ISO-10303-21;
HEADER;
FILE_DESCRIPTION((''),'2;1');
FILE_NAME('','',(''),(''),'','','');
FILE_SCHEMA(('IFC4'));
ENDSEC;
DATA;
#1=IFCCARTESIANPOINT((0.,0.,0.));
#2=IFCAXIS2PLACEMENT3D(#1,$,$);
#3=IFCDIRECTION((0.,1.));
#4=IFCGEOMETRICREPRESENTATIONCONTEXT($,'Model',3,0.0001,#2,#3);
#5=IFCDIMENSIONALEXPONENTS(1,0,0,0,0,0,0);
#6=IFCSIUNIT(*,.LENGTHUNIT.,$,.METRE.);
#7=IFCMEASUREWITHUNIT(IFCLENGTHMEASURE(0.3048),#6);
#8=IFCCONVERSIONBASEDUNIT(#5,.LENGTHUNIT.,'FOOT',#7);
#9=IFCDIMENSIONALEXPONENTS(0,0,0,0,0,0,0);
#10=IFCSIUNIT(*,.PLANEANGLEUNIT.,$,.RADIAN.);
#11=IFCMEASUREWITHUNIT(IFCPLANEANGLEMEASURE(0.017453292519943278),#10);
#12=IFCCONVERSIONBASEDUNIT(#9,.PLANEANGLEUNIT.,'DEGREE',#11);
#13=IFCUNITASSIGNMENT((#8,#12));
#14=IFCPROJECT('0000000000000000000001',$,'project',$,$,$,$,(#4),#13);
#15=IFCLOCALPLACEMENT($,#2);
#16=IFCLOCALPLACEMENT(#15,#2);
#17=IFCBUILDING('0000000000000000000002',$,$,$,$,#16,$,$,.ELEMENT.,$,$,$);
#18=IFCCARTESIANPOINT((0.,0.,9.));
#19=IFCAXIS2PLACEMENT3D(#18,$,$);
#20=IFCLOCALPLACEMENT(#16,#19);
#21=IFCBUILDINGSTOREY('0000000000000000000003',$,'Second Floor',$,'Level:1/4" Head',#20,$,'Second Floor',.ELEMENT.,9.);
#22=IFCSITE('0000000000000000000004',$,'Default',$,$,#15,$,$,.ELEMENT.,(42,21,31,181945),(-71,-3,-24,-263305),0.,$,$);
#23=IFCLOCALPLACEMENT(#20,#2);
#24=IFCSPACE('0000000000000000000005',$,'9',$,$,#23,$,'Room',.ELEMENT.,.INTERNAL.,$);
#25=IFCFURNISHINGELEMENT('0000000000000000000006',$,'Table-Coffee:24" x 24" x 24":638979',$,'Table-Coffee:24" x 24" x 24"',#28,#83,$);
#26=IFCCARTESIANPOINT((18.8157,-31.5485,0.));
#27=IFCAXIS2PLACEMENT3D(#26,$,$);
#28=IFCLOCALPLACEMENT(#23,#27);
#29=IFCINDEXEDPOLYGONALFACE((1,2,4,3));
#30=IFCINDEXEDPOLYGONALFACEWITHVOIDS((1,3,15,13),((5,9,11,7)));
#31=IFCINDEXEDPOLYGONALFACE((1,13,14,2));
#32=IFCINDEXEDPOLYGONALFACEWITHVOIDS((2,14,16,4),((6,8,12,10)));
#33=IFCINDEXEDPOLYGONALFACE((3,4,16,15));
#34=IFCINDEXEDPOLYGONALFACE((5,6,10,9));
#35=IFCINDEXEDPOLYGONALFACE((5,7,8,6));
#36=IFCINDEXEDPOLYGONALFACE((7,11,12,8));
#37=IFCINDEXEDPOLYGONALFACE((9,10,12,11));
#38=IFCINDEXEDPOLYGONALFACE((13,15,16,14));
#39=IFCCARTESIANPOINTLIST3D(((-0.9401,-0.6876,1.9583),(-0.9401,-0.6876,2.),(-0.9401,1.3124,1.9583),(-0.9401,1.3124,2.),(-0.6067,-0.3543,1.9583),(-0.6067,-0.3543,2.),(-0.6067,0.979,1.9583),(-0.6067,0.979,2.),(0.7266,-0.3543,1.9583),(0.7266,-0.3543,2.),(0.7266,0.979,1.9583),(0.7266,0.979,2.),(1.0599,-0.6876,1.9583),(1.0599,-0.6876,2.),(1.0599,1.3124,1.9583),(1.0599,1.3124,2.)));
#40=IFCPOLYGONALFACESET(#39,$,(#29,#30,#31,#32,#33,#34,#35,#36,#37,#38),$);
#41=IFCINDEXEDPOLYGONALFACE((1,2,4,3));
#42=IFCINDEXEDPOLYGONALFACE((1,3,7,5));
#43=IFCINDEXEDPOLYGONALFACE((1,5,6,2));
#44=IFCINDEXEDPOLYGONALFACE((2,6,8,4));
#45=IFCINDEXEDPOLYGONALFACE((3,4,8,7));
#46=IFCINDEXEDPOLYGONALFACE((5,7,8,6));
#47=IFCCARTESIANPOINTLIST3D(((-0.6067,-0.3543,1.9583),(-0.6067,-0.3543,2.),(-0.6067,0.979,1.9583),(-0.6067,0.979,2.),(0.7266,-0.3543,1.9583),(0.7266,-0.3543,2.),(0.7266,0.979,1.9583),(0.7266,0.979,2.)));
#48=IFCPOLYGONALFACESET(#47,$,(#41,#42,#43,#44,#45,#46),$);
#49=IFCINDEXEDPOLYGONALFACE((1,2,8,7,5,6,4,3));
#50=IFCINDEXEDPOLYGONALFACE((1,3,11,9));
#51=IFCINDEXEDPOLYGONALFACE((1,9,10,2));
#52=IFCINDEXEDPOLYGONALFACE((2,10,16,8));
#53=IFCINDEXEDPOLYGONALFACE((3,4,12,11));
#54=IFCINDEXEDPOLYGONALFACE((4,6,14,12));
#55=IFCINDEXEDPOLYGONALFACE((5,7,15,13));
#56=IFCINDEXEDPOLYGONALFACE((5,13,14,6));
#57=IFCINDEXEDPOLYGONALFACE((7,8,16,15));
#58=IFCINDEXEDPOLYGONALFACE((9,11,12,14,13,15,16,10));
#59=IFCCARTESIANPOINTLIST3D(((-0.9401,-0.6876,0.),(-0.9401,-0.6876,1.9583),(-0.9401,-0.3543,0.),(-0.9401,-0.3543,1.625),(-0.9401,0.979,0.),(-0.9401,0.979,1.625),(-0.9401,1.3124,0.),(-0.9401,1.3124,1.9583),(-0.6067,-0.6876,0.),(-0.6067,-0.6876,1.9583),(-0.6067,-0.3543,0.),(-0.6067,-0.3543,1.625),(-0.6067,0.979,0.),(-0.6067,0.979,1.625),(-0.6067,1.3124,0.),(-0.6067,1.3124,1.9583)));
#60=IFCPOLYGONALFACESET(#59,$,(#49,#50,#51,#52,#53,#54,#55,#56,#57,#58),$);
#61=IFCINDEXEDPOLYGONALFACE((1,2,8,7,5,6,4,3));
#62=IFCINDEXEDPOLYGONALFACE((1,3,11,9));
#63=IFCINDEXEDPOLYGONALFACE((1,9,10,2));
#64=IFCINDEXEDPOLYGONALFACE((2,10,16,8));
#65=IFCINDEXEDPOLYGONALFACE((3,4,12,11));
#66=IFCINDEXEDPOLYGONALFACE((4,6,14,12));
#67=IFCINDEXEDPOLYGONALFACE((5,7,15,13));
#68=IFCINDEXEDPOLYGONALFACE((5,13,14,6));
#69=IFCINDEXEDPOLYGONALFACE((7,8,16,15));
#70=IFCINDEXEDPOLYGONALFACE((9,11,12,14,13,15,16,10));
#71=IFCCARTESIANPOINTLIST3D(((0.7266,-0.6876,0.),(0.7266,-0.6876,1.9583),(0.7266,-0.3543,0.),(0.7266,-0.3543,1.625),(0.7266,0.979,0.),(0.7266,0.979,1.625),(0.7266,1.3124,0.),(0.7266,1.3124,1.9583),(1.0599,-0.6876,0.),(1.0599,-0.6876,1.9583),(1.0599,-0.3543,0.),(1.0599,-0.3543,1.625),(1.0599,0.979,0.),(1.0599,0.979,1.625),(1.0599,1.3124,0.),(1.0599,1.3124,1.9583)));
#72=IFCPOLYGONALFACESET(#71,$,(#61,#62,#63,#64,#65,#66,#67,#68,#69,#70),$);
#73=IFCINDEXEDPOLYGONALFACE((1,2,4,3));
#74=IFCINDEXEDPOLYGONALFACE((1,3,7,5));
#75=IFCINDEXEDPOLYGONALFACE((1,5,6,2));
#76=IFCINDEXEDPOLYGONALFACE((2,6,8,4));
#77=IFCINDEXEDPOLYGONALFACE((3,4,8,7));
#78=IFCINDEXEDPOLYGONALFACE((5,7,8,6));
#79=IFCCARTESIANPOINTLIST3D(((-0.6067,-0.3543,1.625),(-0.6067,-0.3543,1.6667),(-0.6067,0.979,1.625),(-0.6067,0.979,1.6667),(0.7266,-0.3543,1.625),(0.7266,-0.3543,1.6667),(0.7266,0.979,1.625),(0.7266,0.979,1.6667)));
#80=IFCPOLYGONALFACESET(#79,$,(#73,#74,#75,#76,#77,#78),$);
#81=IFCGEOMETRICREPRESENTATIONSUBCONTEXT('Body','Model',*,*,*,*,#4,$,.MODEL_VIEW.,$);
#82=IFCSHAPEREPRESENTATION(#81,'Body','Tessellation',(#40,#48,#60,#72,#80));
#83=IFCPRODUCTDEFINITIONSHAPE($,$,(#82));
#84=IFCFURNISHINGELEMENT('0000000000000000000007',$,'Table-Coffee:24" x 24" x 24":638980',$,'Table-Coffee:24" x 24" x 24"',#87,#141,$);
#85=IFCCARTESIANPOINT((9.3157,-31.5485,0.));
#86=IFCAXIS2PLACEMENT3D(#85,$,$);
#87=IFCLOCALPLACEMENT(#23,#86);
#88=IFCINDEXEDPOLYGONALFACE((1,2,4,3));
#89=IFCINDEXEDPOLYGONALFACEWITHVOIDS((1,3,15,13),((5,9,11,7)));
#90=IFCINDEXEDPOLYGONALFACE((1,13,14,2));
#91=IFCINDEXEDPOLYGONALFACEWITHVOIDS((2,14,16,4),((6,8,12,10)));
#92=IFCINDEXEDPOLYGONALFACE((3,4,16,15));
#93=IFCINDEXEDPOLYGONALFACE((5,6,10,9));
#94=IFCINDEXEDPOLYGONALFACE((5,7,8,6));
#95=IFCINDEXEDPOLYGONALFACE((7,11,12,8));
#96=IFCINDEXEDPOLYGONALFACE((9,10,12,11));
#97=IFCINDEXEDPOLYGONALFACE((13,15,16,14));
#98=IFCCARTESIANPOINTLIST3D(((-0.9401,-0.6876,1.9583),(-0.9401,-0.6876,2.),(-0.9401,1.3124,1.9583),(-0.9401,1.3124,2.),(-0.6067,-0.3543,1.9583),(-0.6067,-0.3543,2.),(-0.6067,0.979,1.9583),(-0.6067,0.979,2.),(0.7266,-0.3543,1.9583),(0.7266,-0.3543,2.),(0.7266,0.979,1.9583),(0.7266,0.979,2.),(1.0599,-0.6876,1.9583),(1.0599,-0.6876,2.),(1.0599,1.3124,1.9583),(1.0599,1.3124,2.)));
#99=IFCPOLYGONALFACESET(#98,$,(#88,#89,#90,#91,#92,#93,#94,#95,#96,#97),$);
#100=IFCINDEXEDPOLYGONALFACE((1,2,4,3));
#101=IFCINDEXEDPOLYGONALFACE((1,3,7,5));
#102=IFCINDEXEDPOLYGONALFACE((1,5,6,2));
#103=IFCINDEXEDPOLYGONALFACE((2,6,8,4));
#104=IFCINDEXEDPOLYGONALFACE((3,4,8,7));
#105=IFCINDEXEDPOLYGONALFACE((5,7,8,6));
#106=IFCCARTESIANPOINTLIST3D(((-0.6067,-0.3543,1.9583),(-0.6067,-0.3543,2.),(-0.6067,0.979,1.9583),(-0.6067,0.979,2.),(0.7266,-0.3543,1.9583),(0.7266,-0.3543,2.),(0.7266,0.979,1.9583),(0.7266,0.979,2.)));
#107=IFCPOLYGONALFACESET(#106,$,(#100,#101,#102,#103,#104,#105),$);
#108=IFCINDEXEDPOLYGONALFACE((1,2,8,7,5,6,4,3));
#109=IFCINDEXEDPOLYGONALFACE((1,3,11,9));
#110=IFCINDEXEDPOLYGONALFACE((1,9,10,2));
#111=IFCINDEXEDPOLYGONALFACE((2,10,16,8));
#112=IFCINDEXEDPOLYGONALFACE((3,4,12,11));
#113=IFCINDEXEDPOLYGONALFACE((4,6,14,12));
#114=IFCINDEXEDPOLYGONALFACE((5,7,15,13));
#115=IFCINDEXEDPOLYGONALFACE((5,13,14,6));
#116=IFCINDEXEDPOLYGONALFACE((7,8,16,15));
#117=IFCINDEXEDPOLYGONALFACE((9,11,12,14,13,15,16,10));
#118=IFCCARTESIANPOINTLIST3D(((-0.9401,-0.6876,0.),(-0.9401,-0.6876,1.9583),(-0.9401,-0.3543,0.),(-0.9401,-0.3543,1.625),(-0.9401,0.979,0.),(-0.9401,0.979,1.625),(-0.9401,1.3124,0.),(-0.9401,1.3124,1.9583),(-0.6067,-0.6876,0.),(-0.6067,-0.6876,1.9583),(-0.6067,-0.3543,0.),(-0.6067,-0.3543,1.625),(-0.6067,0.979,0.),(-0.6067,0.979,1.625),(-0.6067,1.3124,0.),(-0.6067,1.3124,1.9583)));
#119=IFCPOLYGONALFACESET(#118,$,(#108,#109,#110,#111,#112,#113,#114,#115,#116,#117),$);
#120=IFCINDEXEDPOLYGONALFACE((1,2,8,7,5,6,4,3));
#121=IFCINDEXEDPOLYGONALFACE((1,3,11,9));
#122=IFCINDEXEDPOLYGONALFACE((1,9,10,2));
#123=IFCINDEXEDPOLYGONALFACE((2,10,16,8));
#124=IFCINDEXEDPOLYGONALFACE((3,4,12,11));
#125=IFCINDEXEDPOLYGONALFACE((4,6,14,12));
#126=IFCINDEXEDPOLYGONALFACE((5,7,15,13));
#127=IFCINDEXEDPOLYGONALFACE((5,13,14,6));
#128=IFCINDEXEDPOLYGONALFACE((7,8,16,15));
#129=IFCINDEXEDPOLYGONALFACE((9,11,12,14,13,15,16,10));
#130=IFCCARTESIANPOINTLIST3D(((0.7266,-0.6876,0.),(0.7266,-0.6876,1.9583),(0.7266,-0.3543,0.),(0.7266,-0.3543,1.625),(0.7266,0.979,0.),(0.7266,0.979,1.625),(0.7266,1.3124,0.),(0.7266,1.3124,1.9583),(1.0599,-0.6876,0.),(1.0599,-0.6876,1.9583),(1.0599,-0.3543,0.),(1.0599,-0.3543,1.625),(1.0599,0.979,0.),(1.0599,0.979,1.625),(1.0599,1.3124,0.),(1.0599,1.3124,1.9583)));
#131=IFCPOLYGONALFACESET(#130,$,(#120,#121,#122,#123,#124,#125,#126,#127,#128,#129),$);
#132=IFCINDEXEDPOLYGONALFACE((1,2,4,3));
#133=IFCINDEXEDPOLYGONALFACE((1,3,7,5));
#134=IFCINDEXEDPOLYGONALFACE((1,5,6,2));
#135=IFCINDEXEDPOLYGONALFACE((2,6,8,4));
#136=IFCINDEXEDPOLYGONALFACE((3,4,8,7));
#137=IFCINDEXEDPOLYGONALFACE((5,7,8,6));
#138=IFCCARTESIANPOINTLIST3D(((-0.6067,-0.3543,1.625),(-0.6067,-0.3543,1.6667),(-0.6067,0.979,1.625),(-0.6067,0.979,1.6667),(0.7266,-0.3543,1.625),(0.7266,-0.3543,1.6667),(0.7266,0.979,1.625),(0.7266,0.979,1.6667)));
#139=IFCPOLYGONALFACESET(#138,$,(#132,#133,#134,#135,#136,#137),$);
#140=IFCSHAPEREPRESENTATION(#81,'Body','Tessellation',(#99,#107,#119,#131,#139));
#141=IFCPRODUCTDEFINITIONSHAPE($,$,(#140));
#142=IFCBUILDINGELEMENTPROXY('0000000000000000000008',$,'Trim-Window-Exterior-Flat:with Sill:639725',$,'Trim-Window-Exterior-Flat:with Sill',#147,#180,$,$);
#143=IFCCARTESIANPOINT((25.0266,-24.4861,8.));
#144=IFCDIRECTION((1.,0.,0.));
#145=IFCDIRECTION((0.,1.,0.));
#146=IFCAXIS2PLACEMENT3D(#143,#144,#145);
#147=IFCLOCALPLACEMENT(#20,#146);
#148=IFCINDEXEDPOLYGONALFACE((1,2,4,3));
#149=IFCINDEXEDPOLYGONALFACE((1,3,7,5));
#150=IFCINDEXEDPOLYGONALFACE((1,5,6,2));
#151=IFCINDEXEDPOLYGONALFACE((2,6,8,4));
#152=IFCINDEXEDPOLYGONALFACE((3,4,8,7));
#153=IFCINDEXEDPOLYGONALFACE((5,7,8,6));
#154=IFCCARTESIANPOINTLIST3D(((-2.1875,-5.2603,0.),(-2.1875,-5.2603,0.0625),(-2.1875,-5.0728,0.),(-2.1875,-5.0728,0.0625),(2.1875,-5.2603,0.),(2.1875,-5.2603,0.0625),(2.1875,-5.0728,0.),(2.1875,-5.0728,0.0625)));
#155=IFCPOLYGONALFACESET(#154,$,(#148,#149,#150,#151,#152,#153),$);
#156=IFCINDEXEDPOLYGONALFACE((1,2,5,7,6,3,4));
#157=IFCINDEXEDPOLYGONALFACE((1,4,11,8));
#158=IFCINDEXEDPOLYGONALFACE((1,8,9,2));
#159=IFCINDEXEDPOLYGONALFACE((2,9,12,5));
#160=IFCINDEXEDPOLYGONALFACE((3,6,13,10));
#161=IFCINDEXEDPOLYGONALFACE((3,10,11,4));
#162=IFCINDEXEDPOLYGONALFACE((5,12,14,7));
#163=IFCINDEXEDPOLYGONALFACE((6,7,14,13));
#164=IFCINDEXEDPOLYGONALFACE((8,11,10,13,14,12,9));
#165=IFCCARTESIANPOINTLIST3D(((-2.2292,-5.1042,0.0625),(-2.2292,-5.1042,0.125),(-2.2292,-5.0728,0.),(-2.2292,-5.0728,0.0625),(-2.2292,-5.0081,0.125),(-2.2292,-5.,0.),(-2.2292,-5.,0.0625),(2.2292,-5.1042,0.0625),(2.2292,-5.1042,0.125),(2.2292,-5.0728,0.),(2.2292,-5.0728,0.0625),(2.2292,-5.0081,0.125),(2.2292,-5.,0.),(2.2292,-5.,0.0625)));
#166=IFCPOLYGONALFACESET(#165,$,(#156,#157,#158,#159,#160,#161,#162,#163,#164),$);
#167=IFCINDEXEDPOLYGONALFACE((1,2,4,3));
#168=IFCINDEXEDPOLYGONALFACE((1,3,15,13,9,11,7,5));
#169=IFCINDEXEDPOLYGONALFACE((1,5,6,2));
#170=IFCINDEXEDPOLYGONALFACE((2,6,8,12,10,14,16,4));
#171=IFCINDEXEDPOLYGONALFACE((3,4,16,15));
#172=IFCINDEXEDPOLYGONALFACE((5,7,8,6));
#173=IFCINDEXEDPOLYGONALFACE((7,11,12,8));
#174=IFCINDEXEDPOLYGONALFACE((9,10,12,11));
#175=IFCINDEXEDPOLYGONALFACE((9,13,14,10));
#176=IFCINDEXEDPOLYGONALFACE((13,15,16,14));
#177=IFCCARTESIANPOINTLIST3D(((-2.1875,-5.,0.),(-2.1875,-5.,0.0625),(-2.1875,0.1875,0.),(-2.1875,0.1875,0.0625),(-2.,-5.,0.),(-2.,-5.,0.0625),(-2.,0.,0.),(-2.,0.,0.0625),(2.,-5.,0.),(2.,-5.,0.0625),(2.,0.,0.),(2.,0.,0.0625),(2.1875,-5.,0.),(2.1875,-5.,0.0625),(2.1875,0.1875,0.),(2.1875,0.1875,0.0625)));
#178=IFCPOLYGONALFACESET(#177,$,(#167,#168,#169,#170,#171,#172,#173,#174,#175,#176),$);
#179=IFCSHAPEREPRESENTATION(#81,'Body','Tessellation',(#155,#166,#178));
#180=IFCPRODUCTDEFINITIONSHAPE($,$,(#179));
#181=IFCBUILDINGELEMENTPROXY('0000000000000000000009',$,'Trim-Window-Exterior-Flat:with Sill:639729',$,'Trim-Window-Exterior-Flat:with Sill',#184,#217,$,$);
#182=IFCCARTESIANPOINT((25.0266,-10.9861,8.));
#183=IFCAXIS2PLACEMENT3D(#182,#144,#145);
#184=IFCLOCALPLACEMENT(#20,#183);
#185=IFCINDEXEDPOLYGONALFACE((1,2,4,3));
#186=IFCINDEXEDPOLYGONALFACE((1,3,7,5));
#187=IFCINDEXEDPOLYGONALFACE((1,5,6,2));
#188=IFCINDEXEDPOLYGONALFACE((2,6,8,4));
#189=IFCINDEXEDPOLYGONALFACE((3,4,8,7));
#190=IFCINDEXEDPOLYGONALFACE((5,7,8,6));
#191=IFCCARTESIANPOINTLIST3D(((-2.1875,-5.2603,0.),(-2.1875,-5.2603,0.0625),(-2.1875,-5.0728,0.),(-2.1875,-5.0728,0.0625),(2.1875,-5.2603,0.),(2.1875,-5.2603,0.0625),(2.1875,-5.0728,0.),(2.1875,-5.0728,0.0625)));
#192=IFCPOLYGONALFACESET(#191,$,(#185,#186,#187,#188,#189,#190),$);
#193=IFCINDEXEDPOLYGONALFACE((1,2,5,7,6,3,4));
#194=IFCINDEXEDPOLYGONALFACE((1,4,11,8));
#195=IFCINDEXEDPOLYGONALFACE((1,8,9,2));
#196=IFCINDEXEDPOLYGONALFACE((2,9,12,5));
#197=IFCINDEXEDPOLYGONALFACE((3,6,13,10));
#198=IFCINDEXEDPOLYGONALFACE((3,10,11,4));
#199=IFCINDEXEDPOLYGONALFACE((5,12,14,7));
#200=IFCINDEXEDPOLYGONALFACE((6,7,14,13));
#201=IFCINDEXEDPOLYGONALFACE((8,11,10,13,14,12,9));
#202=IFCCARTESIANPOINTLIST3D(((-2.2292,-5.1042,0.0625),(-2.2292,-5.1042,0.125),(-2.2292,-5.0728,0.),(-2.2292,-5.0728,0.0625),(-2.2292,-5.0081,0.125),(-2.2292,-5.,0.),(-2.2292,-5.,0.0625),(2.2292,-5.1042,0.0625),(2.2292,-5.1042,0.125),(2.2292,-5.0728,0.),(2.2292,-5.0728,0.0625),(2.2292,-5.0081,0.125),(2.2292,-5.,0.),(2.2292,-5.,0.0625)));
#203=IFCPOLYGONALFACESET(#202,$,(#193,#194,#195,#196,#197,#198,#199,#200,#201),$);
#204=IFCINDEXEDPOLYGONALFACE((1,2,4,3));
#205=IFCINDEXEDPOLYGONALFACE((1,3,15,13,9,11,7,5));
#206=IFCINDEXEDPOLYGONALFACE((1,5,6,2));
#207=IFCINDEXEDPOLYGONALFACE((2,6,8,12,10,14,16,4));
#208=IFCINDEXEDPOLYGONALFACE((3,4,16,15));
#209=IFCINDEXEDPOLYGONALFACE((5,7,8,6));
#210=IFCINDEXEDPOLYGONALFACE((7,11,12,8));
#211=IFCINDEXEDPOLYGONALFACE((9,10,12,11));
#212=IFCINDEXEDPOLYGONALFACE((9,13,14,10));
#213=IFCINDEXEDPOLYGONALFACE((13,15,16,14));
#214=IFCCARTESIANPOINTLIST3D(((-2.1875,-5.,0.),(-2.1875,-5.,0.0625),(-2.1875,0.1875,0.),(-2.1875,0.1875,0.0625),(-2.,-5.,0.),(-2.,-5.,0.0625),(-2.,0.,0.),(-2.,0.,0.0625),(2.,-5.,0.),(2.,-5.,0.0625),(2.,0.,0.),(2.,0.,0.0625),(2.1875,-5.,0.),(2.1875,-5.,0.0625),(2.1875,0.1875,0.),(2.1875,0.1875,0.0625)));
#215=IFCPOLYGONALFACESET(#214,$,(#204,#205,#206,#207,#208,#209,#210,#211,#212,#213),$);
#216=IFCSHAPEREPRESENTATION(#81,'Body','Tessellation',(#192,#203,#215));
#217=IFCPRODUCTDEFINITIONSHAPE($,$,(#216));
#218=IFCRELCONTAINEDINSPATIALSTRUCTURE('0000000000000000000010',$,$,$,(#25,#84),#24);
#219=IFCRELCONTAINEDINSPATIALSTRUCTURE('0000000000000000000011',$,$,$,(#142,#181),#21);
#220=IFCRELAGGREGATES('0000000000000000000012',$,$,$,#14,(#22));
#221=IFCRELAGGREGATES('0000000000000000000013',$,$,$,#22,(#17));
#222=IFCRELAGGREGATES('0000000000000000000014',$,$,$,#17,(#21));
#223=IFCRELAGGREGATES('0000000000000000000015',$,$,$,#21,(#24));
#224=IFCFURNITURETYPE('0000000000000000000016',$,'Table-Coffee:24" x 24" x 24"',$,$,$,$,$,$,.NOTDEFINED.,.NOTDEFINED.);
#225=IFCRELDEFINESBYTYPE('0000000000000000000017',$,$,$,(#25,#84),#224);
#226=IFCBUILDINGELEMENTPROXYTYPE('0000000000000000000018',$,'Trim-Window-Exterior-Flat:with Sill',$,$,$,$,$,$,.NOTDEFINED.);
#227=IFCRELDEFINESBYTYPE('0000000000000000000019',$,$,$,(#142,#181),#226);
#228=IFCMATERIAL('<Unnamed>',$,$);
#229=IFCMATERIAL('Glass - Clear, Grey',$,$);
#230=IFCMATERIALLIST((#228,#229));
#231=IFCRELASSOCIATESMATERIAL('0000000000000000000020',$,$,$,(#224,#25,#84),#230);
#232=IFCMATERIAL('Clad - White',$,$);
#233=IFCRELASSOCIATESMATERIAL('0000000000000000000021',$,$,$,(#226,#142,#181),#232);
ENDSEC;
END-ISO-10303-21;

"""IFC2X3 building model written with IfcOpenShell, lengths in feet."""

from ifc_helpers import new_model, entity, si_unit, converted_unit, direction, frame, frame_2d, origin, origin_2d_with_axis, place, context, subcontext, project, spatial, polyline, rectangle, outline, extrude, source, transform, mapped, material, material_list, type_object, type_shapes, element, save


model = new_model("IFC2X3")

# Units and contexts
model_context = context("Model", 3, precision=0.0001, world=origin(), true_north=direction((0.0, 1.0)))
body_context = subcontext(model_context, "Body", "Model", "MODEL_VIEW")
ifc_project = project(units=[converted_unit("LENGTHUNIT", "FOOT", entity("IfcLengthMeasure", 0.3048), si_unit("LENGTHUNIT", "METRE"), dimensions=[1, 0, 0, 0, 0, 0, 0]), converted_unit("PLANEANGLEUNIT", "DEGREE", entity("IfcPlaneAngleMeasure", 0.017453292519943278), si_unit("PLANEANGLEUNIT", "RADIAN"), dimensions=[0, 0, 0, 0, 0, 0, 0])], contexts=[model_context])

# Site, building, storey
site_placement = place(None, origin())
site = spatial("IfcSite", under=ifc_project, at=site_placement, Name="Default", CompositionType="ELEMENT", RefLatitude=(42, 21, 31, 181945), RefLongitude=(-71, -3, -24, -263305), RefElevation=0.0)
building_placement = place(site_placement, origin())
building = spatial("IfcBuilding", under=site, at=building_placement, CompositionType="ELEMENT")
storey_placement = place(building_placement, frame((0.0, 0.0, 9.0)))
storey = spatial("IfcBuildingStorey", under=building, at=storey_placement, Name="Second Floor", ObjectType="Level:1/4\" Head", LongName="Second Floor", CompositionType="ELEMENT", Elevation=9.0)

# Shared definitions
space_placement = place(storey_placement, origin())
space = spatial("IfcSpace", under=storey, at=space_placement, Name="9", LongName="Room", CompositionType="ELEMENT", InteriorOrExteriorSpace="INTERNAL")

# Furnishing elements
ifc_material_1 = material(Name="<Unnamed>")
ifc_material_2 = material(Name="Glass - Clear, Grey")
ifc_material_list_1 = material_list([ifc_material_1, ifc_material_2])
furniture_type_1 = type_object("IfcFurnitureType", Name="Table-Coffee:24\" x 24\" x 24\"", AssemblyPlace="NOTDEFINED", material=ifc_material_list_1)
shared_shape_1 = source(origin(), body_context, "Body", "SweptSolid", [
    extrude(outline(polyline([(-1.0, -1.0), (1.0, -1.0), (1.0, 1.0), (-1.0, 1.0), (-1.0, -1.0)]), holes=[polyline([(-0.6667, -0.6667), (-0.6667, 0.6667), (0.6667, 0.6667), (0.6667, -0.6667), (-0.6667, -0.6667)])]), frame((0.0599, 0.3124, 1.9583), z_axis=(0.0, 0.0, 1.0), x_axis=(-1.0, 0.0, 0.0)), (0.0, 0.0, 1.0), 0.0417),
    extrude(rectangle(XDim=1.3333, YDim=1.3333, at=origin_2d_with_axis()), frame((0.0599, 0.3124, 1.9583), z_axis=(0.0, 0.0, 1.0), x_axis=(-1.0, 0.0, 0.0)), (0.0, 0.0, 1.0), 0.0417),
    extrude(outline(polyline([(-1.0, -1.0625), (1.0, -1.0625), (1.0, 0.8958), (0.6667, 0.8958), (0.6667, -0.7292), (-0.6667, -0.7292), (-0.6667, 0.8958), (-1.0, 0.8958), (-1.0, -1.0625)])), frame((-0.9401, 0.3124, 0.8958), z_axis=(1.0, 0.0, 0.0), x_axis=(0.0, -1.0, 0.0)), (0.0, 0.0, 1.0), 0.3333),
    extrude(outline(polyline([(-0.8958, -1.0), (1.0625, -1.0), (1.0625, 1.0), (-0.8958, 1.0), (-0.8958, 0.6667), (0.7292, 0.6667), (0.7292, -0.6667), (-0.8958, -0.6667), (-0.8958, -1.0)])), frame((0.7266, 0.3124, 0.8958), z_axis=(1.0, 0.0, 0.0), x_axis=(0.0, 0.0, 1.0)), (0.0, 0.0, 1.0), 0.3333),
    extrude(rectangle(XDim=1.3333, YDim=1.3333, at=origin_2d_with_axis()), frame((0.0599, 0.3124, 1.625), z_axis=(0.0, 0.0, 1.0), x_axis=(-1.0, 0.0, 0.0)), (0.0, 0.0, 1.0), 0.0417),
])
type_shapes(furniture_type_1, [shared_shape_1])
for number, where, name in (
    (1, (18.8157, -31.5485, 0.0), "Table-Coffee:24\" x 24\" x 24\":638979"),
    (2, (9.3157, -31.5485, 0.0), "Table-Coffee:24\" x 24\" x 24\":638980"),
):
    element("IfcFurnishingElement", number, at=place(space_placement, frame(where)), inside=space, type_object=furniture_type_1, material=ifc_material_list_1, Name=name, ObjectType="Table-Coffee:24\" x 24\" x 24\"", context=body_context, shape_type="MappedRepresentation", body=[
        mapped(shared_shape_1, transform((0.0, 0.0, 0.0), scale=1.0)),
    ])

# Building element proxies
ifc_material_3 = material(Name="Clad - White")
building_element_proxy_type_1 = type_object("IfcBuildingElementProxyType", Name="Trim-Window-Exterior-Flat:with Sill", PredefinedType="NOTDEFINED", material=ifc_material_3)
shared_shape_2 = source(origin(), body_context, "Body", "SweptSolid", [
    extrude(rectangle(XDim=4.375, YDim=0.1875, at=frame_2d((0.0, 0.0), x_axis=(1.0, 0.0))), frame((0.0, -5.1665, 0.0), z_axis=(0.0, 0.0, 1.0), x_axis=(-1.0, 0.0, 0.0)), (0.0, 0.0, 1.0), 0.0625),
    extrude(outline(polyline([(-0.0625, -0.0525), (0.0, -0.0525), (0.0, -0.0211), (0.0625, -0.0211), (0.0625, 0.0517), (0.0, 0.0517), (-0.0625, 0.0436), (-0.0625, -0.0525)])), frame((-2.2292, -5.0517, 0.0625), z_axis=(1.0, 0.0, 0.0), x_axis=(0.0, 0.0, -1.0)), (0.0, 0.0, 1.0), 4.4583),
    extrude(outline(polyline([(-2.6406, -2.1875), (2.5469, -2.1875), (2.5469, -2.0), (-2.4531, -2.0), (-2.4531, 2.0), (2.5469, 2.0), (2.5469, 2.1875), (-2.6406, 2.1875), (-2.6406, -2.1875)])), frame((0.0, -2.4531, 0.0), z_axis=(0.0, 0.0, 1.0), x_axis=(0.0, -1.0, 0.0)), (0.0, 0.0, 1.0), 0.0625),
])
type_shapes(building_element_proxy_type_1, [shared_shape_2])
for number, where, z_axis, x_axis, name in (
    (3, (25.0266, -24.4861, 8.0), (1.0, 0.0, 0.0), (0.0, 1.0, 0.0), "Trim-Window-Exterior-Flat:with Sill:639725"),
    (4, (25.0266, -10.9861, 8.0), (1.0, 0.0, 0.0), (0.0, 1.0, 0.0), "Trim-Window-Exterior-Flat:with Sill:639729"),
):
    element("IfcBuildingElementProxy", number, at=place(storey_placement, frame(where, z_axis=z_axis, x_axis=x_axis)), inside=storey, type_object=building_element_proxy_type_1, material=ifc_material_3, Name=name, ObjectType="Trim-Window-Exterior-Flat:with Sill", context=body_context, shape_type="MappedRepresentation", body=[
        mapped(shared_shape_2, transform((0.0, 0.0, 0.0), scale=1.0)),
    ])

save(model, "model.ifc")
